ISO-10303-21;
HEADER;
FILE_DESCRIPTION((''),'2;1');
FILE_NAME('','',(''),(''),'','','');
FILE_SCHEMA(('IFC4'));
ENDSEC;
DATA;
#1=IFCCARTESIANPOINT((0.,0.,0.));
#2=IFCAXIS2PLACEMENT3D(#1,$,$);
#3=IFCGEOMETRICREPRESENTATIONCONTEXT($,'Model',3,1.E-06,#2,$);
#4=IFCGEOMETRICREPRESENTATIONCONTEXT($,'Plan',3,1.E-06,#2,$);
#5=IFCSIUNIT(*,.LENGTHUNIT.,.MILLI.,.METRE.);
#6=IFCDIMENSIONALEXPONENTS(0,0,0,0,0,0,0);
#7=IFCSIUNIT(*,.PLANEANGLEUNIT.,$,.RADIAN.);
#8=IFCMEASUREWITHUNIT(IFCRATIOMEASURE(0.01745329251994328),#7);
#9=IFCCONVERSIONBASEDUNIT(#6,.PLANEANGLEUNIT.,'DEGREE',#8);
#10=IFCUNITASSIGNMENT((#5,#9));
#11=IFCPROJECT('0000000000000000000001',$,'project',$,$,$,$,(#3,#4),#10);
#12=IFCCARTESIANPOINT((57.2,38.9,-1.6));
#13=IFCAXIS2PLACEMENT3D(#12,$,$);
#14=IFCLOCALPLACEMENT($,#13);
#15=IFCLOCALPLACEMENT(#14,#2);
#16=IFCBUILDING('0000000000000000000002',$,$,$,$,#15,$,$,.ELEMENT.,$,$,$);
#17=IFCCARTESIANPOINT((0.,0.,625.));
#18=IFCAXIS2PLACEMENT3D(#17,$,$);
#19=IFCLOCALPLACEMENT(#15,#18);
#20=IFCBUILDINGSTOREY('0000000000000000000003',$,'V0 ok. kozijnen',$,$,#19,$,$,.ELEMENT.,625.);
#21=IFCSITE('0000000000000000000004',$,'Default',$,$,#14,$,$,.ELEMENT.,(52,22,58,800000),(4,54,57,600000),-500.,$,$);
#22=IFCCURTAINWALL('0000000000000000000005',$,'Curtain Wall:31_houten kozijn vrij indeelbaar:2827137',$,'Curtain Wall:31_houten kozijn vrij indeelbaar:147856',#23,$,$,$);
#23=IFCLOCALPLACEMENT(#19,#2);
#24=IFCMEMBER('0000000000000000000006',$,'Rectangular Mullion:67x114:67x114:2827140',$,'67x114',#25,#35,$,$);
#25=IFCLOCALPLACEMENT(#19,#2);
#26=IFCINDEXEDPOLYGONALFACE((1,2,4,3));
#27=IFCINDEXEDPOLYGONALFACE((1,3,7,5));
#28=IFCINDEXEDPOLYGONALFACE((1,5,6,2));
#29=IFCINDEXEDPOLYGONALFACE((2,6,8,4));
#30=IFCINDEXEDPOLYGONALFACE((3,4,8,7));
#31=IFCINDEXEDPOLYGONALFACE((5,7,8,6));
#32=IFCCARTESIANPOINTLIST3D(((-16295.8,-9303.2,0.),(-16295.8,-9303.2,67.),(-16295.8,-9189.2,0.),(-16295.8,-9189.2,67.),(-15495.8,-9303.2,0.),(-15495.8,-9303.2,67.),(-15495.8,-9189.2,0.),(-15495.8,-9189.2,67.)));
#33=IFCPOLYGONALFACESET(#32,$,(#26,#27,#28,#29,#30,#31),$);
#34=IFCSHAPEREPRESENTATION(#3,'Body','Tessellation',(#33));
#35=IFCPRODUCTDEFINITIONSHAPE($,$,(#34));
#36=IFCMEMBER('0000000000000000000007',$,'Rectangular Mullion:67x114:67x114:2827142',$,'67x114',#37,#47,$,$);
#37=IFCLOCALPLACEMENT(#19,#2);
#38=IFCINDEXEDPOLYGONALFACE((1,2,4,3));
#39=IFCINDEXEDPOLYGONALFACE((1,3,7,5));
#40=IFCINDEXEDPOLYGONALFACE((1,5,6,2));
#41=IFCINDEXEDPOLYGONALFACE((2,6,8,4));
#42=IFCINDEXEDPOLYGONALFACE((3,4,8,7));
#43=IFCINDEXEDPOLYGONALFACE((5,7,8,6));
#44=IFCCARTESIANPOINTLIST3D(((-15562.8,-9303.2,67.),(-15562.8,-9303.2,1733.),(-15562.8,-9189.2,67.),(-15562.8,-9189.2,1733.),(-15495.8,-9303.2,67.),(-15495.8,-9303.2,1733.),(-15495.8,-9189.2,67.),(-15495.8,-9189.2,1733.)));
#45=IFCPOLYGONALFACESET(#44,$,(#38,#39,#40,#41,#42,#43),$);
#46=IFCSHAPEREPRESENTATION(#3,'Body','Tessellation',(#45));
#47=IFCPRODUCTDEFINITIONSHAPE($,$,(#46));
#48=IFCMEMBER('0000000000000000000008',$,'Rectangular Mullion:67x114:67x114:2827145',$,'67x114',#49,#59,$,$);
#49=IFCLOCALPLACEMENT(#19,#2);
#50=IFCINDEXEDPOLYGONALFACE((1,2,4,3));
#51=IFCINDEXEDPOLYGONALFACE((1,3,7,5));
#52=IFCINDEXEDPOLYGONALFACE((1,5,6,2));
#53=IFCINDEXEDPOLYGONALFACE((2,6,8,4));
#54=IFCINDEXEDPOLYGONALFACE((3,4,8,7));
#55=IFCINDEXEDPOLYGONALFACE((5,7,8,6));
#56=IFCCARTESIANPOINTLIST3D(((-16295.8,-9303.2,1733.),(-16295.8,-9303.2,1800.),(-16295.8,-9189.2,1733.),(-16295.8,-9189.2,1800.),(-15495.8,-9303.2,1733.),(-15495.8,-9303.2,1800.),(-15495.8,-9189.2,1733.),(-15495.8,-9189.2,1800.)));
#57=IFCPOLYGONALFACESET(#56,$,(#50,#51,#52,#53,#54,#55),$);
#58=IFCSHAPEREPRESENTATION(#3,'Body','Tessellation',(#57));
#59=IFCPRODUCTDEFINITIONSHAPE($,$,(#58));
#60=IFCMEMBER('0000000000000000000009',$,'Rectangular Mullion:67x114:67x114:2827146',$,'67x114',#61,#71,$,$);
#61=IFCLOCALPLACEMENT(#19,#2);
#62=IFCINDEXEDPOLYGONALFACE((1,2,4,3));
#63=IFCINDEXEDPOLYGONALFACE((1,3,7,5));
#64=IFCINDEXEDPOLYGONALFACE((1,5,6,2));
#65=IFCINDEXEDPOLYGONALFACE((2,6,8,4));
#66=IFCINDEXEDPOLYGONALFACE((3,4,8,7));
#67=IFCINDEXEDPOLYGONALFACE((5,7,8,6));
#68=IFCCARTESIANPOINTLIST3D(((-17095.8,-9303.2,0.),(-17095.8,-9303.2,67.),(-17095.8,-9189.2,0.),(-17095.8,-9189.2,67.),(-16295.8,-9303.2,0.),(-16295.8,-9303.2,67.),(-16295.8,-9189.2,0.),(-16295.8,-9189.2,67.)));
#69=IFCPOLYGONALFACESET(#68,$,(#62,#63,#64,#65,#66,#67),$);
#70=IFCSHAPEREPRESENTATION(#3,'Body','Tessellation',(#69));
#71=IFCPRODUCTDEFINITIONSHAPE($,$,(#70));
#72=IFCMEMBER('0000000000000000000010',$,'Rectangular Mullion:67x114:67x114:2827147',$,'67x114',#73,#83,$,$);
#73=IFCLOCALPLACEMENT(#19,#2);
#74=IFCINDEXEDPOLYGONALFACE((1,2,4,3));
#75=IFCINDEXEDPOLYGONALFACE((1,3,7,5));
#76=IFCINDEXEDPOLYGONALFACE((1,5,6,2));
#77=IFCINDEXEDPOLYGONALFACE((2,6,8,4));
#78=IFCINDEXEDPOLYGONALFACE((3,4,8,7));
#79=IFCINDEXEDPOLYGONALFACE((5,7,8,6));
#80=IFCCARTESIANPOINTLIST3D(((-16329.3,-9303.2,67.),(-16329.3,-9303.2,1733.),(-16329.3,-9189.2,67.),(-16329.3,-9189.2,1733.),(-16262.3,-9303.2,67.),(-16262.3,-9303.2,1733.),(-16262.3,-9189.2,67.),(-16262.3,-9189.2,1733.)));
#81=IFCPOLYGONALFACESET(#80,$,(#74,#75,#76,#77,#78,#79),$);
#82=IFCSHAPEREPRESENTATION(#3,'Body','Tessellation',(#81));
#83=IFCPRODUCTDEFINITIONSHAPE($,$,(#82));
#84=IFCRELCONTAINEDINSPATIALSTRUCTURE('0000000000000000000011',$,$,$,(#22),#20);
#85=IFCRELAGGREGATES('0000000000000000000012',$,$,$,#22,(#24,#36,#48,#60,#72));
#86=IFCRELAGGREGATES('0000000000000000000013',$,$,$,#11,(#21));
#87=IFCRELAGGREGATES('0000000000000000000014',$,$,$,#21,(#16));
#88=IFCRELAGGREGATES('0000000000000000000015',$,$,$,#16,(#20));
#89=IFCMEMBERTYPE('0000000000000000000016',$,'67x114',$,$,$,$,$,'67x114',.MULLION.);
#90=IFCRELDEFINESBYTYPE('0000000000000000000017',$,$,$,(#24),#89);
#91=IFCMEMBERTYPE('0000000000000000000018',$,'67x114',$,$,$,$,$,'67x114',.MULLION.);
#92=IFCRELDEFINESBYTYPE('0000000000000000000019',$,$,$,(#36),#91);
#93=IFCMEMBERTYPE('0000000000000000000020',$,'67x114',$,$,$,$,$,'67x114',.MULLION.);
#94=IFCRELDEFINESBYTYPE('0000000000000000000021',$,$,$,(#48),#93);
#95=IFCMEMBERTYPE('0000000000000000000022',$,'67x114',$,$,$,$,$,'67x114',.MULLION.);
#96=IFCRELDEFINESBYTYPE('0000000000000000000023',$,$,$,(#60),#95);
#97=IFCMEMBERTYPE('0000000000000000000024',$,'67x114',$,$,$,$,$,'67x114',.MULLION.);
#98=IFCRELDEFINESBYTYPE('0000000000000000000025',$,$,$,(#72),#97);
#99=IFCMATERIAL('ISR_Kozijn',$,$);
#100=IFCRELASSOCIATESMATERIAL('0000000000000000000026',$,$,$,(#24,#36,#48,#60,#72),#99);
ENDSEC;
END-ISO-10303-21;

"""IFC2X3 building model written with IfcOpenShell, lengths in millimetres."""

from ifc_helpers import new_model, entity, si_unit, converted_unit, frame, origin, origin_2d_with_axis, place, context, project, spatial, rectangle, extrude, source, transform, mapped, material, type_object, type_shapes, element, aggregate, save


model = new_model("IFC2X3")

# Units and contexts
model_context = context("Model", 3, precision=1e-06, world=origin())
plan_context = context("Plan", 3, precision=1e-06, world=origin())
ifc_project = project(units=[si_unit("LENGTHUNIT", "METRE", prefix="MILLI"), converted_unit("PLANEANGLEUNIT", "DEGREE", entity("IfcRatioMeasure", 0.01745329251994328), si_unit("PLANEANGLEUNIT", "RADIAN"), dimensions=[0, 0, 0, 0, 0, 0, 0])], contexts=[model_context, plan_context])

# Site, building, storey
site_placement = place(None, frame((57.2, 38.9, -1.6)))
site = spatial("IfcSite", under=ifc_project, at=site_placement, Name="Default", CompositionType="ELEMENT", RefLatitude=(52, 22, 58, 800000), RefLongitude=(4, 54, 57, 600000), RefElevation=-500.0)
building_placement = place(site_placement, origin())
building = spatial("IfcBuilding", under=site, at=building_placement, CompositionType="ELEMENT")
storey_placement = place(building_placement, frame((0.0, 0.0, 625.0)))
storey = spatial("IfcBuildingStorey", under=building, at=storey_placement, Name="V0 ok. kozijnen", CompositionType="ELEMENT", Elevation=625.0)

# Curtain wall, members
curtain_wall_1_placement = place(storey_placement, origin())
curtain_wall_1 = element("IfcCurtainWall", 1, at=curtain_wall_1_placement, inside=storey, Name="Curtain Wall:31_houten kozijn vrij indeelbaar:2827137", ObjectType="Curtain Wall:31_houten kozijn vrij indeelbaar:147856")
ifc_material_1 = material(Name="ISR_Kozijn")
member_type_1 = type_object("IfcMemberType", Name="67x114", ElementType="67x114", PredefinedType="MULLION")
shared_shape_1 = source(origin(), model_context, "Body", "SweptSolid", [
    extrude(rectangle(XDim=67.0, YDim=114.0, at=origin_2d_with_axis()), frame((-33.5, -57.0, -800.0), z_axis=(0.0, 0.0, 1.0), x_axis=(-1.0, 0.0, 0.0)), (0.0, 0.0, 1.0), 800.0),
])
type_shapes(member_type_1, [shared_shape_1])
member_1_placement = place(storey_placement, frame((-15495.8, -9189.2, 0.0), z_axis=(1.0, 0.0, 0.0), x_axis=(0.0, 0.0, -1.0)))
member_1 = element("IfcMember", 2, at=member_1_placement, type_object=member_type_1, material=ifc_material_1, Name="Rectangular Mullion:67x114:67x114:2827140", ObjectType="67x114", context=model_context, shape_type="MappedRepresentation", body=[
    mapped(shared_shape_1, transform((0.0, 0.0, 0.0), scale=1.0)),
])
member_type_2 = type_object("IfcMemberType", Name="67x114", ElementType="67x114", PredefinedType="MULLION")
shared_shape_2 = source(origin(), model_context, "Body", "SweptSolid", [
    extrude(rectangle(XDim=67.0, YDim=114.0, at=origin_2d_with_axis()), frame((-33.5, -57.0, -1666.0), z_axis=(0.0, 0.0, 1.0), x_axis=(-1.0, 0.0, 0.0)), (0.0, 0.0, 1.0), 1666.0),
])
type_shapes(member_type_2, [shared_shape_2])
member_2_placement = place(storey_placement, frame((-15495.8, -9189.2, 1733.0)))
member_2 = element("IfcMember", 3, at=member_2_placement, type_object=member_type_2, material=ifc_material_1, Name="Rectangular Mullion:67x114:67x114:2827142", ObjectType="67x114", context=model_context, shape_type="MappedRepresentation", body=[
    mapped(shared_shape_2, transform((0.0, 0.0, 0.0), scale=1.0)),
])
member_type_3 = type_object("IfcMemberType", Name="67x114", ElementType="67x114", PredefinedType="MULLION")
shared_shape_3 = source(origin(), model_context, "Body", "SweptSolid", [
    extrude(rectangle(XDim=67.0, YDim=114.0, at=origin_2d_with_axis()), frame((-33.5, -57.0, -800.0), z_axis=(0.0, 0.0, 1.0), x_axis=(-1.0, 0.0, 0.0)), (0.0, 0.0, 1.0), 800.0),
])
type_shapes(member_type_3, [shared_shape_3])
placement = place(building_placement, frame((0.0, 0.0, 2425.0)))
member_3_placement = place(placement, frame((-16295.8, -9189.2, 0.0), z_axis=(-1.0, 0.0, 0.0), x_axis=(0.0, 0.0, 1.0)))
member_3 = element("IfcMember", 4, at=member_3_placement, type_object=member_type_3, material=ifc_material_1, Name="Rectangular Mullion:67x114:67x114:2827145", ObjectType="67x114", context=model_context, shape_type="MappedRepresentation", body=[
    mapped(shared_shape_3, transform((0.0, 0.0, 0.0), scale=1.0)),
])
member_type_4 = type_object("IfcMemberType", Name="67x114", ElementType="67x114", PredefinedType="MULLION")
shared_shape_4 = source(origin(), model_context, "Body", "SweptSolid", [
    extrude(rectangle(XDim=67.0, YDim=114.0, at=origin_2d_with_axis()), frame((-33.5, -57.0, -800.0), z_axis=(0.0, 0.0, 1.0), x_axis=(-1.0, 0.0, 0.0)), (0.0, 0.0, 1.0), 800.0),
])
type_shapes(member_type_4, [shared_shape_4])
member_4_placement = place(storey_placement, frame((-16295.8, -9189.2, 0.0), z_axis=(1.0, 0.0, 0.0), x_axis=(0.0, 0.0, -1.0)))
member_4 = element("IfcMember", 5, at=member_4_placement, type_object=member_type_4, material=ifc_material_1, Name="Rectangular Mullion:67x114:67x114:2827146", ObjectType="67x114", context=model_context, shape_type="MappedRepresentation", body=[
    mapped(shared_shape_4, transform((0.0, 0.0, 0.0), scale=1.0)),
])
member_type_5 = type_object("IfcMemberType", Name="67x114", ElementType="67x114", PredefinedType="MULLION")
shared_shape_5 = source(origin(), model_context, "Body", "SweptSolid", [
    extrude(rectangle(XDim=67.0, YDim=114.0, at=origin_2d_with_axis()), frame((0.0, -57.0, -1666.0), z_axis=(0.0, 0.0, 1.0), x_axis=(-1.0, 0.0, 0.0)), (0.0, 0.0, 1.0), 1666.0),
])
type_shapes(member_type_5, [shared_shape_5])
member_5_placement = place(storey_placement, frame((-16295.8, -9189.2, 67.0), z_axis=(0.0, 0.0, -1.0), x_axis=(-1.0, 0.0, 0.0)))
member_5 = element("IfcMember", 6, at=member_5_placement, type_object=member_type_5, material=ifc_material_1, Name="Rectangular Mullion:67x114:67x114:2827147", ObjectType="67x114", context=model_context, shape_type="MappedRepresentation", body=[
    mapped(shared_shape_5, transform((0.0, 0.0, 0.0), scale=1.0)),
])

aggregate(curtain_wall_1, [member_1, member_2, member_3, member_4, member_5])

save(model, "model.ifc")
